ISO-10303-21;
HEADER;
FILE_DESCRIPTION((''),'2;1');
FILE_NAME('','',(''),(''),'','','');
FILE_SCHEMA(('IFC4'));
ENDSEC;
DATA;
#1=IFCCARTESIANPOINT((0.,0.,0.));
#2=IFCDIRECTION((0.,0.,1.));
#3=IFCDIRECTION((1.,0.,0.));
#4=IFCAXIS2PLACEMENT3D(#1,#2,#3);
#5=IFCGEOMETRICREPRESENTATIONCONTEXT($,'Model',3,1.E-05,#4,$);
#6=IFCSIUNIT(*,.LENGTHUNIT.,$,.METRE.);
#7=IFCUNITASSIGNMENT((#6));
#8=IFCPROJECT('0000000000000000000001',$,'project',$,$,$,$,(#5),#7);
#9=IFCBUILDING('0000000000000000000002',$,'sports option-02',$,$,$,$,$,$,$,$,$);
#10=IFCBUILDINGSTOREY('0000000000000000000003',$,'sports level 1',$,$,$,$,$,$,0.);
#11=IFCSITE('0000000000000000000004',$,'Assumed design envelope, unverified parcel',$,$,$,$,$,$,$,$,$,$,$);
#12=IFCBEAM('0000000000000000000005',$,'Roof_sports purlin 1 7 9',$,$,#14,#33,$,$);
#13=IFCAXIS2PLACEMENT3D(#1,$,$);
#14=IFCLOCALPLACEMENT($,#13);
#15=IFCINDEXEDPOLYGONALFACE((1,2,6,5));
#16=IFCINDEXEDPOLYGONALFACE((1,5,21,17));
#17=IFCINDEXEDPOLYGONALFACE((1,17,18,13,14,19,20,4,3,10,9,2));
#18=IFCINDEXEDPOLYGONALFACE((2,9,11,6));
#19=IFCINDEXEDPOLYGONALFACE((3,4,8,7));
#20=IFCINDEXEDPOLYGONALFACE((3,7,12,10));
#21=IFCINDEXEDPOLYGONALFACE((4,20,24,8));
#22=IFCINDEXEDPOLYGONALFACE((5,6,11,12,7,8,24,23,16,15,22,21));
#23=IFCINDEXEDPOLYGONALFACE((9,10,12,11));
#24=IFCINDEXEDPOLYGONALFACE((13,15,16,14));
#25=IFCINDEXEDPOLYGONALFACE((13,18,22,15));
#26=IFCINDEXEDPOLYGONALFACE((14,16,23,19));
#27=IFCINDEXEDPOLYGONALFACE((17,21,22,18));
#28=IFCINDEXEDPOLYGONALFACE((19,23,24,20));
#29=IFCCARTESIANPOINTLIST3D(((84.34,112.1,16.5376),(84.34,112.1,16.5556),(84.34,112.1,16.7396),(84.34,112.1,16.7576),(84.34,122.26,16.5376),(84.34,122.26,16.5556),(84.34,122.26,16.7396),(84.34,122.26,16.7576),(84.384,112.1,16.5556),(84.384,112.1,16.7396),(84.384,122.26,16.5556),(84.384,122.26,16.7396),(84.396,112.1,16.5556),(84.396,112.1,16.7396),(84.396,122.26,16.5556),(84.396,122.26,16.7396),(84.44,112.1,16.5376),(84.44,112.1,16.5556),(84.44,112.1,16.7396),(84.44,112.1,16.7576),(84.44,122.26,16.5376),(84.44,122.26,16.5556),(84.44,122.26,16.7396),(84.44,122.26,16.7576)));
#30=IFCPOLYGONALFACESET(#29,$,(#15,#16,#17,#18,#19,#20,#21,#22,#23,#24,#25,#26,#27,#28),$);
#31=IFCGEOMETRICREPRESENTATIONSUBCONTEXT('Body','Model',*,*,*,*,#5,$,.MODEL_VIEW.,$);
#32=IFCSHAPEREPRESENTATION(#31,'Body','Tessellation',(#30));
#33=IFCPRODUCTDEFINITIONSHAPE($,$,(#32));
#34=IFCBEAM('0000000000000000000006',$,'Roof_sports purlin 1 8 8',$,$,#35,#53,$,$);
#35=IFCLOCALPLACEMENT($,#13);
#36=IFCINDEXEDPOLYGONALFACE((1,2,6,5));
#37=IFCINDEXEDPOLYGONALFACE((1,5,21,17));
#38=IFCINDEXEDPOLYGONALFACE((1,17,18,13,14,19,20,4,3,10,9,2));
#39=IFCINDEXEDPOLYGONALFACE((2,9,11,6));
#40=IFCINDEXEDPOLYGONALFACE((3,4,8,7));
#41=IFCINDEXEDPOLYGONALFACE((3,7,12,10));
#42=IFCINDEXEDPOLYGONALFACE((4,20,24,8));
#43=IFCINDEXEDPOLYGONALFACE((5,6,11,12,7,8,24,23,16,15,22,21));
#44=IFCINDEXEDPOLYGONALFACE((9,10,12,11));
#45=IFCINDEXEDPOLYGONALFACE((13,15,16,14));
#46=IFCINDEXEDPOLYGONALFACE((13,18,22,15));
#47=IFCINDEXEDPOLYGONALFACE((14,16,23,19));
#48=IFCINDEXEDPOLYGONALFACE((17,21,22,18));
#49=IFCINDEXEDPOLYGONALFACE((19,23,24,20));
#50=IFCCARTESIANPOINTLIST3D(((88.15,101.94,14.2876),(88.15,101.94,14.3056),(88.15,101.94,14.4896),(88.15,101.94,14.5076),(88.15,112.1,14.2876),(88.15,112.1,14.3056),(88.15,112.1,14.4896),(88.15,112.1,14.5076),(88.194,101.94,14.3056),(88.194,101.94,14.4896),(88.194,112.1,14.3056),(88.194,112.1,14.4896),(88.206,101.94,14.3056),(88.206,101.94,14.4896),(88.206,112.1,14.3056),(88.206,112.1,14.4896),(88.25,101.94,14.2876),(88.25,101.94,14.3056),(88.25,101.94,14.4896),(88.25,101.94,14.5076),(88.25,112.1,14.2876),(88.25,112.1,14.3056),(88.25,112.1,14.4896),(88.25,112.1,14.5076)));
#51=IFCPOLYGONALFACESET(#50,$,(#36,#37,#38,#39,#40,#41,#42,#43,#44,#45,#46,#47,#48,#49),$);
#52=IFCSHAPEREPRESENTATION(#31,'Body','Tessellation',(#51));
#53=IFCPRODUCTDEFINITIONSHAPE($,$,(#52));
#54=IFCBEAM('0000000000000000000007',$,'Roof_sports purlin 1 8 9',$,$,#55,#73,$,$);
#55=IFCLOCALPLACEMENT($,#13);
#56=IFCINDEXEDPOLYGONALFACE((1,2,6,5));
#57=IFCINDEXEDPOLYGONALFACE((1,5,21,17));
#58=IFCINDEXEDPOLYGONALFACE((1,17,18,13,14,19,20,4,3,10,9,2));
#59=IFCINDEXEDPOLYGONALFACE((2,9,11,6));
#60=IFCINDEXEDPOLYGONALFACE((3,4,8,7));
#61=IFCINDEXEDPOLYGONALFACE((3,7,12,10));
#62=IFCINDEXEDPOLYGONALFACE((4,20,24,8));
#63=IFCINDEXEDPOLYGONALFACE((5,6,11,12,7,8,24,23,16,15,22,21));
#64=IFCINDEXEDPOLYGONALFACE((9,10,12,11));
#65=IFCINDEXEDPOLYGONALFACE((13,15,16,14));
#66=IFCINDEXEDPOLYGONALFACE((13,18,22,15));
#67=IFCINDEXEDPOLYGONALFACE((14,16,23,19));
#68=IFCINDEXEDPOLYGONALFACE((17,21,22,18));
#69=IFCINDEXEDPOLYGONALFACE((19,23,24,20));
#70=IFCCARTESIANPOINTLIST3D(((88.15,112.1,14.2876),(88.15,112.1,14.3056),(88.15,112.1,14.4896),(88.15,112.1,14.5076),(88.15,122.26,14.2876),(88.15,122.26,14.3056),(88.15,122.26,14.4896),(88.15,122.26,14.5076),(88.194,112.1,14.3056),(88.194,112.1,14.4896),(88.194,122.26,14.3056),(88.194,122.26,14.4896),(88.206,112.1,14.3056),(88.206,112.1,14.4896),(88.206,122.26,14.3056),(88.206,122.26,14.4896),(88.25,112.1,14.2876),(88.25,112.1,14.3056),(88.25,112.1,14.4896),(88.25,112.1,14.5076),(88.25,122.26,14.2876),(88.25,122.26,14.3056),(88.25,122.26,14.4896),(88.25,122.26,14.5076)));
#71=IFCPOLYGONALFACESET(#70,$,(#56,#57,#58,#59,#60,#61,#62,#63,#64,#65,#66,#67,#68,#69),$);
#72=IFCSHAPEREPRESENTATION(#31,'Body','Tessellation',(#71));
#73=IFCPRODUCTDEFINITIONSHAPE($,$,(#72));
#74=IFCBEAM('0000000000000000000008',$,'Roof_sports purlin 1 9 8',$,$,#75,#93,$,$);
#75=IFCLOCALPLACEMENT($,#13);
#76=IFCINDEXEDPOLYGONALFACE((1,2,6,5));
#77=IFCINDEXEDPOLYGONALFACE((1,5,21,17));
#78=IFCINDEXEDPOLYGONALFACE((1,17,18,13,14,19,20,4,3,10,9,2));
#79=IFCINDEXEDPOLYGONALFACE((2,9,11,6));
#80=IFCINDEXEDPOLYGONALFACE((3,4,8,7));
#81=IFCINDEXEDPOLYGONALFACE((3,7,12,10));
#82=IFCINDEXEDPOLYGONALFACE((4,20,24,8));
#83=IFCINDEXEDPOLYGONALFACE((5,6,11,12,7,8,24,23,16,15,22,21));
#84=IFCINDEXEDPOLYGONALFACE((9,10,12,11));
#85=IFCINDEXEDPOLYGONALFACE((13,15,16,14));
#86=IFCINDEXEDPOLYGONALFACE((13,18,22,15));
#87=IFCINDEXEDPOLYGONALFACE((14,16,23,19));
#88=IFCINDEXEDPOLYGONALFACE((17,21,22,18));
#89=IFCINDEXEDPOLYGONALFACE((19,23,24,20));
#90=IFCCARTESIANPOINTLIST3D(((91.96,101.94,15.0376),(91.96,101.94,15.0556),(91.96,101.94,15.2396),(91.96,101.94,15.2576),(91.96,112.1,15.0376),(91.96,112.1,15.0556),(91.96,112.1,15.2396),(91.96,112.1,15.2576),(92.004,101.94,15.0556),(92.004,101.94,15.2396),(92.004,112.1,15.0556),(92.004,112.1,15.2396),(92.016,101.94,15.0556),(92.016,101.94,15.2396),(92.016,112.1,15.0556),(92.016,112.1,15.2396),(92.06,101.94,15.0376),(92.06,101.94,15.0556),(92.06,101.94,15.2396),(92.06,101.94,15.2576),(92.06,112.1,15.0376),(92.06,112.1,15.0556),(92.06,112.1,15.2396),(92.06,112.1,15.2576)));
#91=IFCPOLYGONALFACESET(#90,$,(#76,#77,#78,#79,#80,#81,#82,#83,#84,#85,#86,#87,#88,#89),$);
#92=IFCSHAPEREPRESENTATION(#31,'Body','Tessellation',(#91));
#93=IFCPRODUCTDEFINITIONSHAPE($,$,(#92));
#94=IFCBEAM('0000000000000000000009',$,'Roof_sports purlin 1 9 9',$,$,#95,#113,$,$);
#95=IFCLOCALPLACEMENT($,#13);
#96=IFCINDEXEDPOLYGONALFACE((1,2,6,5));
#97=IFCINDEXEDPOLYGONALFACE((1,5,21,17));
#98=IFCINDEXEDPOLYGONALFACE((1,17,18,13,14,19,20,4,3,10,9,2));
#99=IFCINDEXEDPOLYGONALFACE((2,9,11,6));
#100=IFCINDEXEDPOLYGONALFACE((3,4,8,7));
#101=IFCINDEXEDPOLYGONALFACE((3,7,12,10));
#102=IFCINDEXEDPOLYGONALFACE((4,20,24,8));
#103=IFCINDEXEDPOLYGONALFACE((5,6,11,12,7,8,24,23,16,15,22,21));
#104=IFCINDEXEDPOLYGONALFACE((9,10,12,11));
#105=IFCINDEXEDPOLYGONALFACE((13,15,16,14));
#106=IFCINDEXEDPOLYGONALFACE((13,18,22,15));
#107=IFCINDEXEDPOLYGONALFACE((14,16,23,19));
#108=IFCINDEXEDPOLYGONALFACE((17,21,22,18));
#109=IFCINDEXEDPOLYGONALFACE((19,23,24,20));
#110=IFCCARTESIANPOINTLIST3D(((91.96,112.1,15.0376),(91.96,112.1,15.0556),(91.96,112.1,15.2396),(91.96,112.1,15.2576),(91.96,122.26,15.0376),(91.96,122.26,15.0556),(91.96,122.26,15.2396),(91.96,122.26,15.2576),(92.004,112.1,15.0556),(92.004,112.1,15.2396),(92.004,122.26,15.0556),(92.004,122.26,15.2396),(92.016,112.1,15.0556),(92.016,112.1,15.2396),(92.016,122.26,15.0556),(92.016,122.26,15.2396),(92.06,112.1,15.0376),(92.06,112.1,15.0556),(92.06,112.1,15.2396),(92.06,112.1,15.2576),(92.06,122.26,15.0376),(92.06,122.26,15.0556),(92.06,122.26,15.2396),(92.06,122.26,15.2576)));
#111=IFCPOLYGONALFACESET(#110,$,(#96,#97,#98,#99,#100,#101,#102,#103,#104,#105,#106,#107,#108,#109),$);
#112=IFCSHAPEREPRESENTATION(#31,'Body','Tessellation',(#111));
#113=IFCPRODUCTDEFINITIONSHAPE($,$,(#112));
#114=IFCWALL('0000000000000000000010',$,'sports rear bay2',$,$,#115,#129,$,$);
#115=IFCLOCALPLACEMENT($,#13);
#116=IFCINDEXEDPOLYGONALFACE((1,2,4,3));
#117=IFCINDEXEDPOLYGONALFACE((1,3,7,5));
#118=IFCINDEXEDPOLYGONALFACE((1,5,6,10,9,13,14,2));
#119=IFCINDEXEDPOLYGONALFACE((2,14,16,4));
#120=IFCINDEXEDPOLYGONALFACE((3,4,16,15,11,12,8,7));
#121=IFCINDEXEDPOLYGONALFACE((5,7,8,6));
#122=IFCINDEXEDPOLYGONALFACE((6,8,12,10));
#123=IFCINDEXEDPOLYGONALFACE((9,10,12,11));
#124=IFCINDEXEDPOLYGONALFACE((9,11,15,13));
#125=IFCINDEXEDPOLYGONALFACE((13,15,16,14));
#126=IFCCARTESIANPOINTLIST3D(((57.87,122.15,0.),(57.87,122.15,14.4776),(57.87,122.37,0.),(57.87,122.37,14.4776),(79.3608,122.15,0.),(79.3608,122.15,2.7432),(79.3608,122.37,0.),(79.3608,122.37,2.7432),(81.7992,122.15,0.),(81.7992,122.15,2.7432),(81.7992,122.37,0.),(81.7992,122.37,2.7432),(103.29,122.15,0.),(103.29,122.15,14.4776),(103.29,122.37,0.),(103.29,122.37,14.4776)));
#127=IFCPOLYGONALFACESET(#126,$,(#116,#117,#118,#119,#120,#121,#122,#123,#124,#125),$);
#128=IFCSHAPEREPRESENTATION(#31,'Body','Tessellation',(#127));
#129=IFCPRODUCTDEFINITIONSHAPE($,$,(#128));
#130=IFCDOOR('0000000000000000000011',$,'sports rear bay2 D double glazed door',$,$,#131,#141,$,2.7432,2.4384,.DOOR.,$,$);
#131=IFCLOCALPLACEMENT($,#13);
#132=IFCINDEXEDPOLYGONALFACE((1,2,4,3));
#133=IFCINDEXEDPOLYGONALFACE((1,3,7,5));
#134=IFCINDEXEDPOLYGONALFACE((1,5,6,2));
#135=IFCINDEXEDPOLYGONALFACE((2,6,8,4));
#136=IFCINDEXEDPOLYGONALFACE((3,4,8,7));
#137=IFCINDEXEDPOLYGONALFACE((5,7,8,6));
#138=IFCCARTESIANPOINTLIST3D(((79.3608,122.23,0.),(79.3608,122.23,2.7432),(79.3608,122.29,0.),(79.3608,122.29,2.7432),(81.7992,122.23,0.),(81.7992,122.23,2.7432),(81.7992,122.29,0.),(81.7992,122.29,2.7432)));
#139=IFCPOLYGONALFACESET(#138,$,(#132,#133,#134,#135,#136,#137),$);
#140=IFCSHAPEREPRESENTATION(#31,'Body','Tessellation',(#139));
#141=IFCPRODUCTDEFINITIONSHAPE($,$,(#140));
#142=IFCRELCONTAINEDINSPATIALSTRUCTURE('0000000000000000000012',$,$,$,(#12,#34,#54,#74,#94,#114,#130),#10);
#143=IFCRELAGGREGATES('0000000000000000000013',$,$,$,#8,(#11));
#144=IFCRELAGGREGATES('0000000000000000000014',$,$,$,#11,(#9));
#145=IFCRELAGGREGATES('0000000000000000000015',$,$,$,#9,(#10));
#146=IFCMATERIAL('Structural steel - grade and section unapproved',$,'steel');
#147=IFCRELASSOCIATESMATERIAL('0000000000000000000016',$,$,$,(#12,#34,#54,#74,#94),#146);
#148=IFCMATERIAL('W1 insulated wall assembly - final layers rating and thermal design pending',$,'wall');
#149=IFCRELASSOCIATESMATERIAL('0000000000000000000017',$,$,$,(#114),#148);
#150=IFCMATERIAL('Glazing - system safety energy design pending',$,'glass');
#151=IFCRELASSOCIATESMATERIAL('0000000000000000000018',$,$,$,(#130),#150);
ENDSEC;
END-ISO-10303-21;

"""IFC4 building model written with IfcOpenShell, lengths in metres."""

from ifc_helpers import new_model, si_unit, frame, origin_with_axes, place, context, subcontext, project, spatial, rectangle, i_section, extrude, material, element, fill, save


model = new_model("IFC4")

# Units and contexts
model_context = context("Model", 3, precision=1e-05, world=origin_with_axes())
body_context = subcontext(model_context, "Body", "Model", "MODEL_VIEW")
ifc_project = project(units=[si_unit("LENGTHUNIT", "METRE")], contexts=[model_context])

# Site, building, storey
site = spatial("IfcSite", under=ifc_project, Name="Assumed design envelope, unverified parcel")
building = spatial("IfcBuilding", under=site, Name="sports option-02")
storey = spatial("IfcBuildingStorey", under=building, Name="sports level 1", Elevation=0.0)

# Beams
ifc_material_1 = material(Name="Structural steel - grade and section unapproved", Category="steel")
beam_1_placement = place(None, frame((84.39, 112.1, 16.6476), z_axis=(0.0, 1.0, 0.0), x_axis=(-1.0, 0.0, 0.0)))
element("IfcBeam", 1, at=beam_1_placement, inside=storey, material=ifc_material_1, Name="Roof_sports purlin 1 7 9", context=body_context, shape_type="SweptSolid", body=[
    extrude(i_section(OverallWidth=0.1, OverallDepth=0.22, WebThickness=0.012, FlangeThickness=0.018, FilletRadius=0.0), origin_with_axes(), (0.0, 0.0, 1.0), 10.16),
])
beam_2_placement = place(None, frame((88.2, 101.94, 14.3976), z_axis=(0.0, 1.0, 0.0), x_axis=(-1.0, 0.0, 0.0)))
element("IfcBeam", 2, at=beam_2_placement, inside=storey, material=ifc_material_1, Name="Roof_sports purlin 1 8 8", context=body_context, shape_type="SweptSolid", body=[
    extrude(i_section(OverallWidth=0.1, OverallDepth=0.22, WebThickness=0.012, FlangeThickness=0.018, FilletRadius=0.0), origin_with_axes(), (0.0, 0.0, 1.0), 10.16),
])
beam_3_placement = place(None, frame((88.2, 112.1, 14.3976), z_axis=(0.0, 1.0, 0.0), x_axis=(-1.0, 0.0, 0.0)))
element("IfcBeam", 3, at=beam_3_placement, inside=storey, material=ifc_material_1, Name="Roof_sports purlin 1 8 9", context=body_context, shape_type="SweptSolid", body=[
    extrude(i_section(OverallWidth=0.1, OverallDepth=0.22, WebThickness=0.012, FlangeThickness=0.018, FilletRadius=0.0), origin_with_axes(), (0.0, 0.0, 1.0), 10.16),
])
beam_4_placement = place(None, frame((92.01, 101.94, 15.1476), z_axis=(0.0, 1.0, 0.0), x_axis=(-1.0, 0.0, 0.0)))
element("IfcBeam", 4, at=beam_4_placement, inside=storey, material=ifc_material_1, Name="Roof_sports purlin 1 9 8", context=body_context, shape_type="SweptSolid", body=[
    extrude(i_section(OverallWidth=0.1, OverallDepth=0.22, WebThickness=0.012, FlangeThickness=0.018, FilletRadius=0.0), origin_with_axes(), (0.0, 0.0, 1.0), 10.16),
])
beam_5_placement = place(None, frame((92.01, 112.1, 15.1476), z_axis=(0.0, 1.0, 0.0), x_axis=(-1.0, 0.0, 0.0)))
element("IfcBeam", 5, at=beam_5_placement, inside=storey, material=ifc_material_1, Name="Roof_sports purlin 1 9 9", context=body_context, shape_type="SweptSolid", body=[
    extrude(i_section(OverallWidth=0.1, OverallDepth=0.22, WebThickness=0.012, FlangeThickness=0.018, FilletRadius=0.0), origin_with_axes(), (0.0, 0.0, 1.0), 10.16),
])

# Wall, opening, door
ifc_material_2 = material(Name="W1 insulated wall assembly - final layers rating and thermal design pending", Category="wall")
wall_placement = place(None, frame((80.58, 122.26, 0.0), z_axis=(0.0, 0.0, 1.0), x_axis=(1.0, 0.0, 0.0)))
wall = element("IfcWall", 6, at=wall_placement, inside=storey, material=ifc_material_2, Name="sports rear bay2", context=body_context, shape_type="SweptSolid", body=[
    extrude(rectangle(XDim=45.42, YDim=0.22), origin_with_axes(), (0.0, 0.0, 1.0), 14.4776),
])
opening_placement = place(None, frame((80.58, 122.26, 0.0), z_axis=(0.0, 0.0, 1.0), x_axis=(1.0, 0.0, 0.0)))
opening = element("IfcOpeningElement", 7, at=opening_placement, cuts=wall, context=body_context, shape_type="SweptSolid", body=[
    extrude(rectangle(XDim=2.4384, YDim=0.32), origin_with_axes(), (0.0, 0.0, 1.0), 2.7432),
])
ifc_material_3 = material(Name="Glazing - system safety energy design pending", Category="glass")
door_placement = place(None, frame((80.58, 122.26, 0.0), z_axis=(0.0, 0.0, 1.0), x_axis=(1.0, 0.0, 0.0)))
door = element("IfcDoor", 8, at=door_placement, inside=storey, material=ifc_material_3, Name="sports rear bay2 D double glazed door", OverallHeight=2.7432, OverallWidth=2.4384, PredefinedType="DOOR", context=body_context, shape_type="SweptSolid", body=[
    extrude(rectangle(XDim=2.4384, YDim=0.06), origin_with_axes(), (0.0, 0.0, 1.0), 2.7432),
])
fill(opening, door)

save(model, "model.ifc")
